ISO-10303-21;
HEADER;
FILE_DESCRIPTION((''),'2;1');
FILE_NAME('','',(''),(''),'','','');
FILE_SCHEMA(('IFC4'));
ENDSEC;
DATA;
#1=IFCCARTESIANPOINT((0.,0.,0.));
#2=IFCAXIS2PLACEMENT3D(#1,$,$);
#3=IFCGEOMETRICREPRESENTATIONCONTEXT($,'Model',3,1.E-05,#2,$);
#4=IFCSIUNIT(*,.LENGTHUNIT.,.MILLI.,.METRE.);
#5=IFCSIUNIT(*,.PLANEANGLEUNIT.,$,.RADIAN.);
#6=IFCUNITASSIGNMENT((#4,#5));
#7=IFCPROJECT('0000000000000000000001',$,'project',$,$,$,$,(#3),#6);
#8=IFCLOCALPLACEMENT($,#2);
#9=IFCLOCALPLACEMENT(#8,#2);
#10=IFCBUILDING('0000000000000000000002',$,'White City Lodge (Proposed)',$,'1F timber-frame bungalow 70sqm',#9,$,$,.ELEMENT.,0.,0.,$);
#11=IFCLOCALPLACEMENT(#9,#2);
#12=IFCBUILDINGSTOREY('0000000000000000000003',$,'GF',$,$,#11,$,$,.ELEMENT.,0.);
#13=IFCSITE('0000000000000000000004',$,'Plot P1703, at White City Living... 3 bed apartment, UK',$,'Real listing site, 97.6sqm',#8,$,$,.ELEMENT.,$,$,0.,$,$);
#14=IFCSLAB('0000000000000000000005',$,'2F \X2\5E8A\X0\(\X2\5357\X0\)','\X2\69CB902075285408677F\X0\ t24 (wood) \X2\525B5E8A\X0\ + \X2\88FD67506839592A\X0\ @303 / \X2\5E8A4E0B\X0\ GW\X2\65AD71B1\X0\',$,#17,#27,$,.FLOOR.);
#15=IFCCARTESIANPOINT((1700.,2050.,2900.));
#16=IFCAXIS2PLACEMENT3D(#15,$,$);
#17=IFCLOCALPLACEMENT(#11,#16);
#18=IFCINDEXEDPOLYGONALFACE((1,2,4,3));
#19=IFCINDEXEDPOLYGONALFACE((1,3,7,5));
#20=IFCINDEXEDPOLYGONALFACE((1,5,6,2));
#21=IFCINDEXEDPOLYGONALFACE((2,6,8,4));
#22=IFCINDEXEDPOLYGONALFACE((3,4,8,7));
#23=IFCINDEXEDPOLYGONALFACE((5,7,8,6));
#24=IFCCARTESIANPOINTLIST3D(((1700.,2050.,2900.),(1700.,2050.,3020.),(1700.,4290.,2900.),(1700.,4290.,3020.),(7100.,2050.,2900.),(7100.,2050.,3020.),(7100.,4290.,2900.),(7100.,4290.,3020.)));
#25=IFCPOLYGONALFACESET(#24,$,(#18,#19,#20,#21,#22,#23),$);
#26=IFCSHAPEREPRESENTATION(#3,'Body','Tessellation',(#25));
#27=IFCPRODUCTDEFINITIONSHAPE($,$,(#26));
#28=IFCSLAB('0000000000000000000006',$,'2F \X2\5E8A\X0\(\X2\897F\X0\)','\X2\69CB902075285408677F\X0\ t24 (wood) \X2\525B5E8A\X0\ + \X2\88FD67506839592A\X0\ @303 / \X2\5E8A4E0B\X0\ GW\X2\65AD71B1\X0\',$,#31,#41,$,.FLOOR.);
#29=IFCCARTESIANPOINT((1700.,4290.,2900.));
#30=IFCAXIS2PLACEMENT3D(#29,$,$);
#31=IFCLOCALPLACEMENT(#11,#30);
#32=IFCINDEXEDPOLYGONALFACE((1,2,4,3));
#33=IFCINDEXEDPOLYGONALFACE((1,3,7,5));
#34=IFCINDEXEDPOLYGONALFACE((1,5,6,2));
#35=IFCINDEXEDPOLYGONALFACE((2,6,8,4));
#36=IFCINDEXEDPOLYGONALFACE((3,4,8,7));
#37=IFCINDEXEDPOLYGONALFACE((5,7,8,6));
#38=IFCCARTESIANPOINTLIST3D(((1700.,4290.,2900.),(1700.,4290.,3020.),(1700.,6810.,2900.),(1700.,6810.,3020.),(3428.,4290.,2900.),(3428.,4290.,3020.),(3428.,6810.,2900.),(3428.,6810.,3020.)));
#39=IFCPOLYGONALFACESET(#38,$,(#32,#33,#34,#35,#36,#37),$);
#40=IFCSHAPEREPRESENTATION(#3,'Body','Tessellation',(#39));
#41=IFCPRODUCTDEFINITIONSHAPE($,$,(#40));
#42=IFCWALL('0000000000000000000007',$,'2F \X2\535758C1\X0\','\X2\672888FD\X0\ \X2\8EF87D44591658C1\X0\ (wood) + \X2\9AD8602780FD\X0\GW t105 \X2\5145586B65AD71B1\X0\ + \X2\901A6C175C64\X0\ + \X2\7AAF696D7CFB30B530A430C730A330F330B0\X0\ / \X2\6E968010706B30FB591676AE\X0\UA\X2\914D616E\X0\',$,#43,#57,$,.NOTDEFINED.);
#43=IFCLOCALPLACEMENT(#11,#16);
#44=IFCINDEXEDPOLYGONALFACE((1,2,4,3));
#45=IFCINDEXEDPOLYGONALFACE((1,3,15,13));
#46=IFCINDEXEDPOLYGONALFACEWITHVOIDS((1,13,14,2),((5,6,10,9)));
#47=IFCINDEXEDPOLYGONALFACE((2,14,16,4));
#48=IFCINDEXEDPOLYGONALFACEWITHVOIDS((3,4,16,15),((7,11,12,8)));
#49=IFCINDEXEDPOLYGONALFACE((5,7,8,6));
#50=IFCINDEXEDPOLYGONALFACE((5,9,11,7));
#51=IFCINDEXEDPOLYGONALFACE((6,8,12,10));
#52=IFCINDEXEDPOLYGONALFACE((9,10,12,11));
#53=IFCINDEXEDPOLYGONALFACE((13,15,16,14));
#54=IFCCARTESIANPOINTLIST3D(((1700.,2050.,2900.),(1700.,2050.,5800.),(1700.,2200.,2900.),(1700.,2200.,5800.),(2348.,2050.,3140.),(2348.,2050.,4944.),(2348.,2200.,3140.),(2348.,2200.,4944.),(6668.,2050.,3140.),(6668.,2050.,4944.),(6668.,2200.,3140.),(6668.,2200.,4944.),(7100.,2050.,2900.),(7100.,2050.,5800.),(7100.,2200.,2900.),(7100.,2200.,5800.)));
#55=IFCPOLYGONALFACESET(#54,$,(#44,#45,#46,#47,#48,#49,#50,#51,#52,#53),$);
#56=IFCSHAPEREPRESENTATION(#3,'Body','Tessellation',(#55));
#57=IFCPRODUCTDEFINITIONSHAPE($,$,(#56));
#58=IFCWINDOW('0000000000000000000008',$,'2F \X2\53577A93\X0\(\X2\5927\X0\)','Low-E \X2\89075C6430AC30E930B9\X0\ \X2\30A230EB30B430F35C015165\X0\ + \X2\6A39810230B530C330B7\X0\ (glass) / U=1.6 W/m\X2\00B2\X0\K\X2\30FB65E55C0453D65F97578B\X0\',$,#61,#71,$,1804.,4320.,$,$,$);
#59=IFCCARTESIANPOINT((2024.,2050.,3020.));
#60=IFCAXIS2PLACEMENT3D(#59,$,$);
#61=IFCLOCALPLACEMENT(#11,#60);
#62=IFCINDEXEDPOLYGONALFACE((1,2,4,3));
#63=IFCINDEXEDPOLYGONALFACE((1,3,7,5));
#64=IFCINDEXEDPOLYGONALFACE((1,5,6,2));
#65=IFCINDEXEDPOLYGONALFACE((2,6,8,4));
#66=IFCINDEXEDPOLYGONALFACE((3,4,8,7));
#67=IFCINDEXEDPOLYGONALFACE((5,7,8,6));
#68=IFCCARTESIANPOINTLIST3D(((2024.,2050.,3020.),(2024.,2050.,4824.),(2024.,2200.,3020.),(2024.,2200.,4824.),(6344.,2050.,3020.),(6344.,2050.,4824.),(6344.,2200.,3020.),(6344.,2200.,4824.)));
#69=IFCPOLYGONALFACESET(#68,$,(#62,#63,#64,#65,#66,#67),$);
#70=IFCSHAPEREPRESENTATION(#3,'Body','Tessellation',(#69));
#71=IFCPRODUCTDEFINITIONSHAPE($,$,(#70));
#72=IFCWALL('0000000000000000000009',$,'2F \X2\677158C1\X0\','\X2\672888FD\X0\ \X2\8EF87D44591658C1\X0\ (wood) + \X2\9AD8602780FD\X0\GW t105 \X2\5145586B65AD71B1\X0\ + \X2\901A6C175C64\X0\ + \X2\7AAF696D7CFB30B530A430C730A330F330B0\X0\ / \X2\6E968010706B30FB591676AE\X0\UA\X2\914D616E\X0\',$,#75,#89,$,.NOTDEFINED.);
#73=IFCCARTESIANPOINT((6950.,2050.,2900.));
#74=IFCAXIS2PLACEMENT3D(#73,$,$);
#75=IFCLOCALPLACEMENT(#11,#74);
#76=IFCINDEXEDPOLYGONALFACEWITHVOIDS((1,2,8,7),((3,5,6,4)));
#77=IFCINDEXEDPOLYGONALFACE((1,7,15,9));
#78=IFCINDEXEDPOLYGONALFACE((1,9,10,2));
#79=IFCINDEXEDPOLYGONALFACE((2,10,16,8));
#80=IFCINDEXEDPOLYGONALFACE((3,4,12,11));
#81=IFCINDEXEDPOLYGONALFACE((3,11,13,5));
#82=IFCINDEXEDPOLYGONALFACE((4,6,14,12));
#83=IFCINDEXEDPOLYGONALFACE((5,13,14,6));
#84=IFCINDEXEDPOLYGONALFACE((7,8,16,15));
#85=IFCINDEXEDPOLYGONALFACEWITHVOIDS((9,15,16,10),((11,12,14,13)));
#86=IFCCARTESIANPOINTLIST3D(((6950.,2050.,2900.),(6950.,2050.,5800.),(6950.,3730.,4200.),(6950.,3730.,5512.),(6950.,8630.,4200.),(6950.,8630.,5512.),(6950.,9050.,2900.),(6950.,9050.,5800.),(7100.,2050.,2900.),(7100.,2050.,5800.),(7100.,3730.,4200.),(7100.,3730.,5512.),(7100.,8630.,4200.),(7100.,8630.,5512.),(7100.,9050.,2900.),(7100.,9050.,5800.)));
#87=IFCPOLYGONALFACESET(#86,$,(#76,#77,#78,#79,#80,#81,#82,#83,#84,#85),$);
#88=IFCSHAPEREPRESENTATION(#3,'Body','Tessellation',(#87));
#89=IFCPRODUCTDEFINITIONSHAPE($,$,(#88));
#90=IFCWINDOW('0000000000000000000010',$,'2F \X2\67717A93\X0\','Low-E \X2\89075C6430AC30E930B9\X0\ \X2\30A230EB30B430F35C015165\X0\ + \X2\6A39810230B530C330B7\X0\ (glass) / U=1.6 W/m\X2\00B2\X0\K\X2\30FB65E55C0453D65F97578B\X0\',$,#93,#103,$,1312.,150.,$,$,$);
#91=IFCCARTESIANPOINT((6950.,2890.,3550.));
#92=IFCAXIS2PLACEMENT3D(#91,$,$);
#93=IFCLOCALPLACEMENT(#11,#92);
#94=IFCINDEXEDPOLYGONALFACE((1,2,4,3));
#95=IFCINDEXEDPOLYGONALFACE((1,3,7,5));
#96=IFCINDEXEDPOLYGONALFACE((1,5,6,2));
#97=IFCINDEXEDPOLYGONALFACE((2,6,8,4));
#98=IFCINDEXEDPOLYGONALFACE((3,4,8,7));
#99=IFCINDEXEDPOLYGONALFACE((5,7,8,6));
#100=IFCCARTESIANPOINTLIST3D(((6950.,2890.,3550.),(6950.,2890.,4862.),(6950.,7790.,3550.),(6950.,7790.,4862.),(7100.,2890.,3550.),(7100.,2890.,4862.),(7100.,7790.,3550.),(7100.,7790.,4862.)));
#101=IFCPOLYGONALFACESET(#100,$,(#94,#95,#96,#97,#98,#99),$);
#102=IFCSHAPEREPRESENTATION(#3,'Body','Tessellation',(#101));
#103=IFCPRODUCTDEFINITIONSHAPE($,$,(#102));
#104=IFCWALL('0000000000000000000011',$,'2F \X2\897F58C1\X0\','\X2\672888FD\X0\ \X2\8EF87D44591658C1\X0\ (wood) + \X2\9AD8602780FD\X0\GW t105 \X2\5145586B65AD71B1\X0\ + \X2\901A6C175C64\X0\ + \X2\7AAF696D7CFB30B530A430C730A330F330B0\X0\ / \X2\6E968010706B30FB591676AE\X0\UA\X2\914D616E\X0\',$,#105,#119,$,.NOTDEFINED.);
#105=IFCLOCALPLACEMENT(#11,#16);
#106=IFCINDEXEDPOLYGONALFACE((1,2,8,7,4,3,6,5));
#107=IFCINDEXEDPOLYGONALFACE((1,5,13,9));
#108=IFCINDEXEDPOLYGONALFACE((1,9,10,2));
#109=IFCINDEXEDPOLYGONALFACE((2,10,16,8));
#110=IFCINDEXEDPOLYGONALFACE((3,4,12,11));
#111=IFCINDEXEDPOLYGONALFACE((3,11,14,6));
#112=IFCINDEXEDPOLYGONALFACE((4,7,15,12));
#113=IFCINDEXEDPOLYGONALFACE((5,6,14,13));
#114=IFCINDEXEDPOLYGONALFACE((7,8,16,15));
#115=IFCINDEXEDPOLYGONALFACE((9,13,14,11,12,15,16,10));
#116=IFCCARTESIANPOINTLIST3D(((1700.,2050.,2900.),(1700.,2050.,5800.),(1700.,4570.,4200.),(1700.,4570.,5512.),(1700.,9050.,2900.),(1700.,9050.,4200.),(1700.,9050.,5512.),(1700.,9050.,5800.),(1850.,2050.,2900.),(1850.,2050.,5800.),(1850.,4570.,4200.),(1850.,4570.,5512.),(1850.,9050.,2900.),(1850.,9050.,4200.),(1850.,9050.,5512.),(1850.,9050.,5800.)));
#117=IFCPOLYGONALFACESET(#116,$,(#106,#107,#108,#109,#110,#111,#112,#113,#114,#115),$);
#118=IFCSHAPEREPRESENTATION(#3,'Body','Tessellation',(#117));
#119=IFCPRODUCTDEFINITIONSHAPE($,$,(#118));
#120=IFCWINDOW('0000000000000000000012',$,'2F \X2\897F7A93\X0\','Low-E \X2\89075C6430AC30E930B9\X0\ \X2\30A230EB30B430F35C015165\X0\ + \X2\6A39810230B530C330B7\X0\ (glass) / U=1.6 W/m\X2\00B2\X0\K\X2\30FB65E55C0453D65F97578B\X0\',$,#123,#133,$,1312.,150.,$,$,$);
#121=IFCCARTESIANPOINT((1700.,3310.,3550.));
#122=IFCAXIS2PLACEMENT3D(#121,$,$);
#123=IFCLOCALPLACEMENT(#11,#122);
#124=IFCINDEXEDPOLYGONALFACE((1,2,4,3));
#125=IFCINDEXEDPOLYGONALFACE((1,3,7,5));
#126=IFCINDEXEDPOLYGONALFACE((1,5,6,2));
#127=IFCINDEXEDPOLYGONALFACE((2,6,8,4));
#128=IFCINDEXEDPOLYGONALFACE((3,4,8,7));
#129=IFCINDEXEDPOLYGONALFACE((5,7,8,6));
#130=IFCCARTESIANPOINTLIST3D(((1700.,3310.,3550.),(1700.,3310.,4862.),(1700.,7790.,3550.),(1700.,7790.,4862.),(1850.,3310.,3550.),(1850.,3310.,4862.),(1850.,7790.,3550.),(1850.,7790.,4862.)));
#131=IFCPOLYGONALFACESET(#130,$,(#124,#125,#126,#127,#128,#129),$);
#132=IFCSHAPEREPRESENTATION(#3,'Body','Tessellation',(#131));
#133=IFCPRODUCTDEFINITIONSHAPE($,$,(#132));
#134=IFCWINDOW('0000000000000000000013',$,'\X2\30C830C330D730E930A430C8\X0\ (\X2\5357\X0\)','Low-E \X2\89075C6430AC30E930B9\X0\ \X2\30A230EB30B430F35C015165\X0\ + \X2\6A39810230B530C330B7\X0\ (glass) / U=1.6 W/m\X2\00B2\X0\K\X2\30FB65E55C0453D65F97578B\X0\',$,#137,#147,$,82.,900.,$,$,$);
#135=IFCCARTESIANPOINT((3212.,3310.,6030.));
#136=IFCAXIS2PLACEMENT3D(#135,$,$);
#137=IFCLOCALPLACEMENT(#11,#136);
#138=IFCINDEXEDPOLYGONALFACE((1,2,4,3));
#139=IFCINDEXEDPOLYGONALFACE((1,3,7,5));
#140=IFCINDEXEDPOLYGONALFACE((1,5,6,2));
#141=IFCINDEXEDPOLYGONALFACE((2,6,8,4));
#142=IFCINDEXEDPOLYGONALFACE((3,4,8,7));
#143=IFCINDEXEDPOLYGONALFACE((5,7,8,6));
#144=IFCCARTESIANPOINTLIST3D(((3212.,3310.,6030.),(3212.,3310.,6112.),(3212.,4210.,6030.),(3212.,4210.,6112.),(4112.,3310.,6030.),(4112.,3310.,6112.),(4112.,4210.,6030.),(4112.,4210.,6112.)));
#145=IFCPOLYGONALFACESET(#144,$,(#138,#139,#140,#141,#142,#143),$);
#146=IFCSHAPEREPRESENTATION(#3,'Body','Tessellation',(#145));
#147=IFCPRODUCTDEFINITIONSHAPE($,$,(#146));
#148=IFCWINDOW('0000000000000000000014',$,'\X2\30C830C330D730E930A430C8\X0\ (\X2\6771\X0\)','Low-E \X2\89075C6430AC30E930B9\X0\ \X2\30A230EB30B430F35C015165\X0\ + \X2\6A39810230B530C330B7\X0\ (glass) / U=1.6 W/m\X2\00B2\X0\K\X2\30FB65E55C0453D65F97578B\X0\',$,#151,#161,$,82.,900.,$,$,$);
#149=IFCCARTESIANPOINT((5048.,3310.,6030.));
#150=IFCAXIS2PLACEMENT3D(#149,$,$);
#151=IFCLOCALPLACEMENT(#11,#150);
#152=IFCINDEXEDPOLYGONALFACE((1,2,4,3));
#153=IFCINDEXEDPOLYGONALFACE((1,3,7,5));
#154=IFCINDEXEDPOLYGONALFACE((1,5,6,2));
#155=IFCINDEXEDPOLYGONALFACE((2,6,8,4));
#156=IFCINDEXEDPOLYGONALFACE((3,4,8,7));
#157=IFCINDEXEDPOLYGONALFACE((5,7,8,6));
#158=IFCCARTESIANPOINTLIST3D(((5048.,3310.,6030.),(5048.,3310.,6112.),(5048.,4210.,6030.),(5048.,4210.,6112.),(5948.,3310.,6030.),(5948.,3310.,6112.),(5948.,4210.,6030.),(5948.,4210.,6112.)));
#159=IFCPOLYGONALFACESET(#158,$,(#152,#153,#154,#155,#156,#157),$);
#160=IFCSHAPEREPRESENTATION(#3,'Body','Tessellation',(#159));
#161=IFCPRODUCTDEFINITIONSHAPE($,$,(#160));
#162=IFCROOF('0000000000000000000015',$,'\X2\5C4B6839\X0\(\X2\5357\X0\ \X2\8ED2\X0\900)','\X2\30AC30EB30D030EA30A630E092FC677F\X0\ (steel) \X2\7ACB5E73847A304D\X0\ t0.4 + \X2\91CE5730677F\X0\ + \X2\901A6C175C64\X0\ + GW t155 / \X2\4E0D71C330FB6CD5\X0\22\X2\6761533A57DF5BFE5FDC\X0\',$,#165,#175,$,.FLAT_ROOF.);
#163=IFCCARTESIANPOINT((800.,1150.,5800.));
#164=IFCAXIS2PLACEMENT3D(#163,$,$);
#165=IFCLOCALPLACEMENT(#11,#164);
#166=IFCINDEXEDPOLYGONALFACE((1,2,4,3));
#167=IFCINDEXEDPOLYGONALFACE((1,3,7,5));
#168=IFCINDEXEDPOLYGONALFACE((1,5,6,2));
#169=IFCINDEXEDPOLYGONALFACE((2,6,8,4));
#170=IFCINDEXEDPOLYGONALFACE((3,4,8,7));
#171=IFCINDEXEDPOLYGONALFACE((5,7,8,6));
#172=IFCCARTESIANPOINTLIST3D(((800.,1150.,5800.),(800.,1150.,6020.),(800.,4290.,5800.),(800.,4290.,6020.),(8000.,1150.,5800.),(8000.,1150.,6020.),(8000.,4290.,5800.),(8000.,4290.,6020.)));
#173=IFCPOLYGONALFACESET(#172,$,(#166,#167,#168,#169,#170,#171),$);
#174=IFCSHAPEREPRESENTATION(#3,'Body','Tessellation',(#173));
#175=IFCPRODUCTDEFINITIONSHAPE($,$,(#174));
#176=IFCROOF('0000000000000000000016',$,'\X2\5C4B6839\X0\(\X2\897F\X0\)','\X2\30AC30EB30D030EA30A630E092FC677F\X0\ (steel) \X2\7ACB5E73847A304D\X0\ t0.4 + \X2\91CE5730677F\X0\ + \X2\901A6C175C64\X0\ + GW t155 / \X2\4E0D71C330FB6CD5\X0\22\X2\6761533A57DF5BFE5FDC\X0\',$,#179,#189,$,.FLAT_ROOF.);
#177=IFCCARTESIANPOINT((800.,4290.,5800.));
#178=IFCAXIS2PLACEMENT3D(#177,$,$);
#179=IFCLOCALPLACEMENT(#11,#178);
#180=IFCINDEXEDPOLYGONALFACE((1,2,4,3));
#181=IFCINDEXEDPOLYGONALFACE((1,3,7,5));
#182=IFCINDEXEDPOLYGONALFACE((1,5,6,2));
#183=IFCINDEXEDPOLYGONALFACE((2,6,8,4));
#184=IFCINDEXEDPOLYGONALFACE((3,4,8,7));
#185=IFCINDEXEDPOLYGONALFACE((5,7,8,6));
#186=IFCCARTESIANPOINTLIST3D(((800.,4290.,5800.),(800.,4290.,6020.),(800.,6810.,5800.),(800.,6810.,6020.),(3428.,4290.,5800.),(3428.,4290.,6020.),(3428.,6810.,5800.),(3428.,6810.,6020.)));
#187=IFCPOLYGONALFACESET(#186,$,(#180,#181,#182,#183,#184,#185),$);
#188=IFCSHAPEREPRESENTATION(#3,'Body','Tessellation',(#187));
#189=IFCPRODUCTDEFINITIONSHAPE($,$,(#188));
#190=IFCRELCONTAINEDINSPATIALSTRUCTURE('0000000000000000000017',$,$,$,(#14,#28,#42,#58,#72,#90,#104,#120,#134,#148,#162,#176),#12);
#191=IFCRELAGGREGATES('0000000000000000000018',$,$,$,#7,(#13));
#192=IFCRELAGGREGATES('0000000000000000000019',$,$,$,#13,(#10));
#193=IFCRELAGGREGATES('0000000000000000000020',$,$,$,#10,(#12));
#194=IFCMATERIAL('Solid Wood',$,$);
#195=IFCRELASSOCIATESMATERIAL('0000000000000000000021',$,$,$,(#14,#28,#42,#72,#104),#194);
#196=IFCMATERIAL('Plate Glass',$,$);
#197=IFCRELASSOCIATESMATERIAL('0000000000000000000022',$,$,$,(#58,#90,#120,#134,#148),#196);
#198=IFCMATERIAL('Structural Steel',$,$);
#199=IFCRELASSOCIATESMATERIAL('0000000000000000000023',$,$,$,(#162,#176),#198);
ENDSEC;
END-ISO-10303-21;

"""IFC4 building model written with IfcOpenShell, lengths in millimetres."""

from ifc_helpers import new_model, si_unit, frame, frame_2d, origin, place, context, project, spatial, rectangle, extrude, material, element, fill, save


model = new_model("IFC4")

# Units and contexts
model_context = context("Model", 3, precision=1e-05, world=origin())
ifc_project = project(units=[si_unit("LENGTHUNIT", "METRE", prefix="MILLI"), si_unit("PLANEANGLEUNIT", "RADIAN")], contexts=[model_context])

# Site, building, storey
site_placement = place(None, origin())
site = spatial("IfcSite", under=ifc_project, at=site_placement, Name="Plot P1703, at White City Living... 3 bed apartment, UK", ObjectType="Real listing site, 97.6sqm", CompositionType="ELEMENT", RefElevation=0.0)
building_placement = place(site_placement, origin())
building = spatial("IfcBuilding", under=site, at=building_placement, Name="White City Lodge (Proposed)", ObjectType="1F timber-frame bungalow 70sqm", CompositionType="ELEMENT", ElevationOfRefHeight=0.0, ElevationOfTerrain=0.0)
storey_placement = place(building_placement, origin())
storey = spatial("IfcBuildingStorey", under=building, at=storey_placement, Name="GF", CompositionType="ELEMENT", Elevation=0.0)

# Slabs
ifc_material_1 = material(Name="Solid Wood")
slab_1_placement = place(storey_placement, frame((1700.0, 2050.0, 2900.0)))
element("IfcSlab", 1, at=slab_1_placement, inside=storey, material=ifc_material_1, Name="2F 床(南)", Description="構造用合板 t24 (wood) 剛床 + 製材根太 @303 / 床下 GW断熱", PredefinedType="FLOOR", context=model_context, shape_type="SweptSolid", body=[
    extrude(rectangle(XDim=5400.0, YDim=2240.0, at=frame_2d((2700.0, 1120.0))), frame((1700.0, 2050.0, 2900.0)), (0.0, 0.0, 1.0), 120.0),
])
slab_2_placement = place(storey_placement, frame((1700.0, 4290.0, 2900.0)))
element("IfcSlab", 2, at=slab_2_placement, inside=storey, material=ifc_material_1, Name="2F 床(西)", Description="構造用合板 t24 (wood) 剛床 + 製材根太 @303 / 床下 GW断熱", PredefinedType="FLOOR", context=model_context, shape_type="SweptSolid", body=[
    extrude(rectangle(XDim=1728.0, YDim=2520.0, at=frame_2d((864.0, 1260.0))), frame((1700.0, 4290.0, 2900.0)), (0.0, 0.0, 1.0), 120.0),
])

# Walls, openings, windows
wall_1_placement = place(storey_placement, frame((1700.0, 2050.0, 2900.0)))
wall_1 = element("IfcWall", 3, at=wall_1_placement, inside=storey, material=ifc_material_1, Name="2F 南壁", Description="木製 軸組外壁 (wood) + 高性能GW t105 充填断熱 + 通気層 + 窯業系サイディング / 準耐火・外皮UA配慮", PredefinedType="NOTDEFINED", context=model_context, shape_type="SweptSolid", body=[
    extrude(rectangle(XDim=5400.0, YDim=150.0, at=frame_2d((2700.0, 75.0))), frame((1700.0, 2050.0, 2900.0)), (0.0, 0.0, 1.0), 2900.0),
])
opening_1_placement = place(storey_placement, frame((2024.0, 2050.0, 3020.0)))
opening_1 = element("IfcOpeningElement", 4, at=opening_1_placement, cuts=wall_1, PredefinedType="NOTDEFINED", context=model_context, shape_type="SweptSolid", body=[
    extrude(rectangle(XDim=4320.0, YDim=150.0, at=frame_2d((2160.0, 75.0))), frame((2024.0, 2050.0, 3020.0)), (0.0, 0.0, 1.0), 1804.0),
])
ifc_material_2 = material(Name="Plate Glass")
window_1_placement = place(storey_placement, frame((2024.0, 2050.0, 3020.0)))
window_1 = element("IfcWindow", 5, at=window_1_placement, inside=storey, material=ifc_material_2, Name="2F 南窓(大)", Description="Low-E 複層ガラス アルゴン封入 + 樹脂サッシ (glass) / U=1.6 W/m²K・日射取得型", OverallHeight=1804.0, OverallWidth=4320.0, context=model_context, shape_type="SweptSolid", body=[
    extrude(rectangle(XDim=4320.0, YDim=150.0, at=frame_2d((2160.0, 75.0))), frame((2024.0, 2050.0, 3020.0)), (0.0, 0.0, 1.0), 1804.0),
])
fill(opening_1, window_1)
wall_2_placement = place(storey_placement, frame((6950.0, 2050.0, 2900.0)))
wall_2 = element("IfcWall", 6, at=wall_2_placement, inside=storey, material=ifc_material_1, Name="2F 東壁", Description="木製 軸組外壁 (wood) + 高性能GW t105 充填断熱 + 通気層 + 窯業系サイディング / 準耐火・外皮UA配慮", PredefinedType="NOTDEFINED", context=model_context, shape_type="SweptSolid", body=[
    extrude(rectangle(XDim=150.0, YDim=7000.0, at=frame_2d((75.0, 3500.0))), frame((6950.0, 2050.0, 2900.0)), (0.0, 0.0, 1.0), 2900.0),
])
opening_2_placement = place(storey_placement, frame((6950.0, 2890.0, 3550.0)))
opening_2 = element("IfcOpeningElement", 7, at=opening_2_placement, cuts=wall_2, PredefinedType="NOTDEFINED", context=model_context, shape_type="SweptSolid", body=[
    extrude(rectangle(XDim=150.0, YDim=4900.0, at=frame_2d((75.0, 2450.0))), frame((6950.0, 2890.0, 3550.0)), (0.0, 0.0, 1.0), 1312.0),
])
window_2_placement = place(storey_placement, frame((6950.0, 2890.0, 3550.0)))
window_2 = element("IfcWindow", 8, at=window_2_placement, inside=storey, material=ifc_material_2, Name="2F 東窓", Description="Low-E 複層ガラス アルゴン封入 + 樹脂サッシ (glass) / U=1.6 W/m²K・日射取得型", OverallHeight=1312.0, OverallWidth=150.0, context=model_context, shape_type="SweptSolid", body=[
    extrude(rectangle(XDim=150.0, YDim=4900.0, at=frame_2d((75.0, 2450.0))), frame((6950.0, 2890.0, 3550.0)), (0.0, 0.0, 1.0), 1312.0),
])
fill(opening_2, window_2)
wall_3_placement = place(storey_placement, frame((1700.0, 2050.0, 2900.0)))
wall_3 = element("IfcWall", 9, at=wall_3_placement, inside=storey, material=ifc_material_1, Name="2F 西壁", Description="木製 軸組外壁 (wood) + 高性能GW t105 充填断熱 + 通気層 + 窯業系サイディング / 準耐火・外皮UA配慮", PredefinedType="NOTDEFINED", context=model_context, shape_type="SweptSolid", body=[
    extrude(rectangle(XDim=150.0, YDim=7000.0, at=frame_2d((75.0, 3500.0))), frame((1700.0, 2050.0, 2900.0)), (0.0, 0.0, 1.0), 2900.0),
])
opening_3_placement = place(storey_placement, frame((1700.0, 3310.0, 3550.0)))
opening_3 = element("IfcOpeningElement", 10, at=opening_3_placement, cuts=wall_3, PredefinedType="NOTDEFINED", context=model_context, shape_type="SweptSolid", body=[
    extrude(rectangle(XDim=150.0, YDim=4480.0, at=frame_2d((75.0, 2240.0))), frame((1700.0, 3310.0, 3550.0)), (0.0, 0.0, 1.0), 1312.0),
])
window_3_placement = place(storey_placement, frame((1700.0, 3310.0, 3550.0)))
window_3 = element("IfcWindow", 11, at=window_3_placement, inside=storey, material=ifc_material_2, Name="2F 西窓", Description="Low-E 複層ガラス アルゴン封入 + 樹脂サッシ (glass) / U=1.6 W/m²K・日射取得型", OverallHeight=1312.0, OverallWidth=150.0, context=model_context, shape_type="SweptSolid", body=[
    extrude(rectangle(XDim=150.0, YDim=4480.0, at=frame_2d((75.0, 2240.0))), frame((1700.0, 3310.0, 3550.0)), (0.0, 0.0, 1.0), 1312.0),
])
fill(opening_3, window_3)

# Windows
window_4_placement = place(storey_placement, frame((3212.0, 3310.0, 6030.0)))
element("IfcWindow", 12, at=window_4_placement, inside=storey, material=ifc_material_2, Name="トップライト (南)", Description="Low-E 複層ガラス アルゴン封入 + 樹脂サッシ (glass) / U=1.6 W/m²K・日射取得型", OverallHeight=82.0, OverallWidth=900.0, context=model_context, shape_type="SweptSolid", body=[
    extrude(rectangle(XDim=900.0, YDim=900.0, at=frame_2d((450.0, 450.0))), frame((3212.0, 3310.0, 6030.0)), (0.0, 0.0, 1.0), 82.0),
])
window_5_placement = place(storey_placement, frame((5048.0, 3310.0, 6030.0)))
element("IfcWindow", 13, at=window_5_placement, inside=storey, material=ifc_material_2, Name="トップライト (東)", Description="Low-E 複層ガラス アルゴン封入 + 樹脂サッシ (glass) / U=1.6 W/m²K・日射取得型", OverallHeight=82.0, OverallWidth=900.0, context=model_context, shape_type="SweptSolid", body=[
    extrude(rectangle(XDim=900.0, YDim=900.0, at=frame_2d((450.0, 450.0))), frame((5048.0, 3310.0, 6030.0)), (0.0, 0.0, 1.0), 82.0),
])

# Roofs
ifc_material_3 = material(Name="Structural Steel")
roof_1_placement = place(storey_placement, frame((800.0, 1150.0, 5800.0)))
element("IfcRoof", 14, at=roof_1_placement, inside=storey, material=ifc_material_3, Name="屋根(南 軒900)", Description="ガルバリウム鋼板 (steel) 立平葺き t0.4 + 野地板 + 通気層 + GW t155 / 不燃・法22条区域対応", PredefinedType="FLAT_ROOF", context=model_context, shape_type="SweptSolid", body=[
    extrude(rectangle(XDim=7200.0, YDim=3140.0, at=frame_2d((3600.0, 1570.0))), frame((800.0, 1150.0, 5800.0)), (0.0, 0.0, 1.0), 220.0),
])
roof_2_placement = place(storey_placement, frame((800.0, 4290.0, 5800.0)))
element("IfcRoof", 15, at=roof_2_placement, inside=storey, material=ifc_material_3, Name="屋根(西)", Description="ガルバリウム鋼板 (steel) 立平葺き t0.4 + 野地板 + 通気層 + GW t155 / 不燃・法22条区域対応", PredefinedType="FLAT_ROOF", context=model_context, shape_type="SweptSolid", body=[
    extrude(rectangle(XDim=2628.0, YDim=2520.0, at=frame_2d((1314.0, 1260.0))), frame((800.0, 4290.0, 5800.0)), (0.0, 0.0, 1.0), 220.0),
])

save(model, "model.ifc")
